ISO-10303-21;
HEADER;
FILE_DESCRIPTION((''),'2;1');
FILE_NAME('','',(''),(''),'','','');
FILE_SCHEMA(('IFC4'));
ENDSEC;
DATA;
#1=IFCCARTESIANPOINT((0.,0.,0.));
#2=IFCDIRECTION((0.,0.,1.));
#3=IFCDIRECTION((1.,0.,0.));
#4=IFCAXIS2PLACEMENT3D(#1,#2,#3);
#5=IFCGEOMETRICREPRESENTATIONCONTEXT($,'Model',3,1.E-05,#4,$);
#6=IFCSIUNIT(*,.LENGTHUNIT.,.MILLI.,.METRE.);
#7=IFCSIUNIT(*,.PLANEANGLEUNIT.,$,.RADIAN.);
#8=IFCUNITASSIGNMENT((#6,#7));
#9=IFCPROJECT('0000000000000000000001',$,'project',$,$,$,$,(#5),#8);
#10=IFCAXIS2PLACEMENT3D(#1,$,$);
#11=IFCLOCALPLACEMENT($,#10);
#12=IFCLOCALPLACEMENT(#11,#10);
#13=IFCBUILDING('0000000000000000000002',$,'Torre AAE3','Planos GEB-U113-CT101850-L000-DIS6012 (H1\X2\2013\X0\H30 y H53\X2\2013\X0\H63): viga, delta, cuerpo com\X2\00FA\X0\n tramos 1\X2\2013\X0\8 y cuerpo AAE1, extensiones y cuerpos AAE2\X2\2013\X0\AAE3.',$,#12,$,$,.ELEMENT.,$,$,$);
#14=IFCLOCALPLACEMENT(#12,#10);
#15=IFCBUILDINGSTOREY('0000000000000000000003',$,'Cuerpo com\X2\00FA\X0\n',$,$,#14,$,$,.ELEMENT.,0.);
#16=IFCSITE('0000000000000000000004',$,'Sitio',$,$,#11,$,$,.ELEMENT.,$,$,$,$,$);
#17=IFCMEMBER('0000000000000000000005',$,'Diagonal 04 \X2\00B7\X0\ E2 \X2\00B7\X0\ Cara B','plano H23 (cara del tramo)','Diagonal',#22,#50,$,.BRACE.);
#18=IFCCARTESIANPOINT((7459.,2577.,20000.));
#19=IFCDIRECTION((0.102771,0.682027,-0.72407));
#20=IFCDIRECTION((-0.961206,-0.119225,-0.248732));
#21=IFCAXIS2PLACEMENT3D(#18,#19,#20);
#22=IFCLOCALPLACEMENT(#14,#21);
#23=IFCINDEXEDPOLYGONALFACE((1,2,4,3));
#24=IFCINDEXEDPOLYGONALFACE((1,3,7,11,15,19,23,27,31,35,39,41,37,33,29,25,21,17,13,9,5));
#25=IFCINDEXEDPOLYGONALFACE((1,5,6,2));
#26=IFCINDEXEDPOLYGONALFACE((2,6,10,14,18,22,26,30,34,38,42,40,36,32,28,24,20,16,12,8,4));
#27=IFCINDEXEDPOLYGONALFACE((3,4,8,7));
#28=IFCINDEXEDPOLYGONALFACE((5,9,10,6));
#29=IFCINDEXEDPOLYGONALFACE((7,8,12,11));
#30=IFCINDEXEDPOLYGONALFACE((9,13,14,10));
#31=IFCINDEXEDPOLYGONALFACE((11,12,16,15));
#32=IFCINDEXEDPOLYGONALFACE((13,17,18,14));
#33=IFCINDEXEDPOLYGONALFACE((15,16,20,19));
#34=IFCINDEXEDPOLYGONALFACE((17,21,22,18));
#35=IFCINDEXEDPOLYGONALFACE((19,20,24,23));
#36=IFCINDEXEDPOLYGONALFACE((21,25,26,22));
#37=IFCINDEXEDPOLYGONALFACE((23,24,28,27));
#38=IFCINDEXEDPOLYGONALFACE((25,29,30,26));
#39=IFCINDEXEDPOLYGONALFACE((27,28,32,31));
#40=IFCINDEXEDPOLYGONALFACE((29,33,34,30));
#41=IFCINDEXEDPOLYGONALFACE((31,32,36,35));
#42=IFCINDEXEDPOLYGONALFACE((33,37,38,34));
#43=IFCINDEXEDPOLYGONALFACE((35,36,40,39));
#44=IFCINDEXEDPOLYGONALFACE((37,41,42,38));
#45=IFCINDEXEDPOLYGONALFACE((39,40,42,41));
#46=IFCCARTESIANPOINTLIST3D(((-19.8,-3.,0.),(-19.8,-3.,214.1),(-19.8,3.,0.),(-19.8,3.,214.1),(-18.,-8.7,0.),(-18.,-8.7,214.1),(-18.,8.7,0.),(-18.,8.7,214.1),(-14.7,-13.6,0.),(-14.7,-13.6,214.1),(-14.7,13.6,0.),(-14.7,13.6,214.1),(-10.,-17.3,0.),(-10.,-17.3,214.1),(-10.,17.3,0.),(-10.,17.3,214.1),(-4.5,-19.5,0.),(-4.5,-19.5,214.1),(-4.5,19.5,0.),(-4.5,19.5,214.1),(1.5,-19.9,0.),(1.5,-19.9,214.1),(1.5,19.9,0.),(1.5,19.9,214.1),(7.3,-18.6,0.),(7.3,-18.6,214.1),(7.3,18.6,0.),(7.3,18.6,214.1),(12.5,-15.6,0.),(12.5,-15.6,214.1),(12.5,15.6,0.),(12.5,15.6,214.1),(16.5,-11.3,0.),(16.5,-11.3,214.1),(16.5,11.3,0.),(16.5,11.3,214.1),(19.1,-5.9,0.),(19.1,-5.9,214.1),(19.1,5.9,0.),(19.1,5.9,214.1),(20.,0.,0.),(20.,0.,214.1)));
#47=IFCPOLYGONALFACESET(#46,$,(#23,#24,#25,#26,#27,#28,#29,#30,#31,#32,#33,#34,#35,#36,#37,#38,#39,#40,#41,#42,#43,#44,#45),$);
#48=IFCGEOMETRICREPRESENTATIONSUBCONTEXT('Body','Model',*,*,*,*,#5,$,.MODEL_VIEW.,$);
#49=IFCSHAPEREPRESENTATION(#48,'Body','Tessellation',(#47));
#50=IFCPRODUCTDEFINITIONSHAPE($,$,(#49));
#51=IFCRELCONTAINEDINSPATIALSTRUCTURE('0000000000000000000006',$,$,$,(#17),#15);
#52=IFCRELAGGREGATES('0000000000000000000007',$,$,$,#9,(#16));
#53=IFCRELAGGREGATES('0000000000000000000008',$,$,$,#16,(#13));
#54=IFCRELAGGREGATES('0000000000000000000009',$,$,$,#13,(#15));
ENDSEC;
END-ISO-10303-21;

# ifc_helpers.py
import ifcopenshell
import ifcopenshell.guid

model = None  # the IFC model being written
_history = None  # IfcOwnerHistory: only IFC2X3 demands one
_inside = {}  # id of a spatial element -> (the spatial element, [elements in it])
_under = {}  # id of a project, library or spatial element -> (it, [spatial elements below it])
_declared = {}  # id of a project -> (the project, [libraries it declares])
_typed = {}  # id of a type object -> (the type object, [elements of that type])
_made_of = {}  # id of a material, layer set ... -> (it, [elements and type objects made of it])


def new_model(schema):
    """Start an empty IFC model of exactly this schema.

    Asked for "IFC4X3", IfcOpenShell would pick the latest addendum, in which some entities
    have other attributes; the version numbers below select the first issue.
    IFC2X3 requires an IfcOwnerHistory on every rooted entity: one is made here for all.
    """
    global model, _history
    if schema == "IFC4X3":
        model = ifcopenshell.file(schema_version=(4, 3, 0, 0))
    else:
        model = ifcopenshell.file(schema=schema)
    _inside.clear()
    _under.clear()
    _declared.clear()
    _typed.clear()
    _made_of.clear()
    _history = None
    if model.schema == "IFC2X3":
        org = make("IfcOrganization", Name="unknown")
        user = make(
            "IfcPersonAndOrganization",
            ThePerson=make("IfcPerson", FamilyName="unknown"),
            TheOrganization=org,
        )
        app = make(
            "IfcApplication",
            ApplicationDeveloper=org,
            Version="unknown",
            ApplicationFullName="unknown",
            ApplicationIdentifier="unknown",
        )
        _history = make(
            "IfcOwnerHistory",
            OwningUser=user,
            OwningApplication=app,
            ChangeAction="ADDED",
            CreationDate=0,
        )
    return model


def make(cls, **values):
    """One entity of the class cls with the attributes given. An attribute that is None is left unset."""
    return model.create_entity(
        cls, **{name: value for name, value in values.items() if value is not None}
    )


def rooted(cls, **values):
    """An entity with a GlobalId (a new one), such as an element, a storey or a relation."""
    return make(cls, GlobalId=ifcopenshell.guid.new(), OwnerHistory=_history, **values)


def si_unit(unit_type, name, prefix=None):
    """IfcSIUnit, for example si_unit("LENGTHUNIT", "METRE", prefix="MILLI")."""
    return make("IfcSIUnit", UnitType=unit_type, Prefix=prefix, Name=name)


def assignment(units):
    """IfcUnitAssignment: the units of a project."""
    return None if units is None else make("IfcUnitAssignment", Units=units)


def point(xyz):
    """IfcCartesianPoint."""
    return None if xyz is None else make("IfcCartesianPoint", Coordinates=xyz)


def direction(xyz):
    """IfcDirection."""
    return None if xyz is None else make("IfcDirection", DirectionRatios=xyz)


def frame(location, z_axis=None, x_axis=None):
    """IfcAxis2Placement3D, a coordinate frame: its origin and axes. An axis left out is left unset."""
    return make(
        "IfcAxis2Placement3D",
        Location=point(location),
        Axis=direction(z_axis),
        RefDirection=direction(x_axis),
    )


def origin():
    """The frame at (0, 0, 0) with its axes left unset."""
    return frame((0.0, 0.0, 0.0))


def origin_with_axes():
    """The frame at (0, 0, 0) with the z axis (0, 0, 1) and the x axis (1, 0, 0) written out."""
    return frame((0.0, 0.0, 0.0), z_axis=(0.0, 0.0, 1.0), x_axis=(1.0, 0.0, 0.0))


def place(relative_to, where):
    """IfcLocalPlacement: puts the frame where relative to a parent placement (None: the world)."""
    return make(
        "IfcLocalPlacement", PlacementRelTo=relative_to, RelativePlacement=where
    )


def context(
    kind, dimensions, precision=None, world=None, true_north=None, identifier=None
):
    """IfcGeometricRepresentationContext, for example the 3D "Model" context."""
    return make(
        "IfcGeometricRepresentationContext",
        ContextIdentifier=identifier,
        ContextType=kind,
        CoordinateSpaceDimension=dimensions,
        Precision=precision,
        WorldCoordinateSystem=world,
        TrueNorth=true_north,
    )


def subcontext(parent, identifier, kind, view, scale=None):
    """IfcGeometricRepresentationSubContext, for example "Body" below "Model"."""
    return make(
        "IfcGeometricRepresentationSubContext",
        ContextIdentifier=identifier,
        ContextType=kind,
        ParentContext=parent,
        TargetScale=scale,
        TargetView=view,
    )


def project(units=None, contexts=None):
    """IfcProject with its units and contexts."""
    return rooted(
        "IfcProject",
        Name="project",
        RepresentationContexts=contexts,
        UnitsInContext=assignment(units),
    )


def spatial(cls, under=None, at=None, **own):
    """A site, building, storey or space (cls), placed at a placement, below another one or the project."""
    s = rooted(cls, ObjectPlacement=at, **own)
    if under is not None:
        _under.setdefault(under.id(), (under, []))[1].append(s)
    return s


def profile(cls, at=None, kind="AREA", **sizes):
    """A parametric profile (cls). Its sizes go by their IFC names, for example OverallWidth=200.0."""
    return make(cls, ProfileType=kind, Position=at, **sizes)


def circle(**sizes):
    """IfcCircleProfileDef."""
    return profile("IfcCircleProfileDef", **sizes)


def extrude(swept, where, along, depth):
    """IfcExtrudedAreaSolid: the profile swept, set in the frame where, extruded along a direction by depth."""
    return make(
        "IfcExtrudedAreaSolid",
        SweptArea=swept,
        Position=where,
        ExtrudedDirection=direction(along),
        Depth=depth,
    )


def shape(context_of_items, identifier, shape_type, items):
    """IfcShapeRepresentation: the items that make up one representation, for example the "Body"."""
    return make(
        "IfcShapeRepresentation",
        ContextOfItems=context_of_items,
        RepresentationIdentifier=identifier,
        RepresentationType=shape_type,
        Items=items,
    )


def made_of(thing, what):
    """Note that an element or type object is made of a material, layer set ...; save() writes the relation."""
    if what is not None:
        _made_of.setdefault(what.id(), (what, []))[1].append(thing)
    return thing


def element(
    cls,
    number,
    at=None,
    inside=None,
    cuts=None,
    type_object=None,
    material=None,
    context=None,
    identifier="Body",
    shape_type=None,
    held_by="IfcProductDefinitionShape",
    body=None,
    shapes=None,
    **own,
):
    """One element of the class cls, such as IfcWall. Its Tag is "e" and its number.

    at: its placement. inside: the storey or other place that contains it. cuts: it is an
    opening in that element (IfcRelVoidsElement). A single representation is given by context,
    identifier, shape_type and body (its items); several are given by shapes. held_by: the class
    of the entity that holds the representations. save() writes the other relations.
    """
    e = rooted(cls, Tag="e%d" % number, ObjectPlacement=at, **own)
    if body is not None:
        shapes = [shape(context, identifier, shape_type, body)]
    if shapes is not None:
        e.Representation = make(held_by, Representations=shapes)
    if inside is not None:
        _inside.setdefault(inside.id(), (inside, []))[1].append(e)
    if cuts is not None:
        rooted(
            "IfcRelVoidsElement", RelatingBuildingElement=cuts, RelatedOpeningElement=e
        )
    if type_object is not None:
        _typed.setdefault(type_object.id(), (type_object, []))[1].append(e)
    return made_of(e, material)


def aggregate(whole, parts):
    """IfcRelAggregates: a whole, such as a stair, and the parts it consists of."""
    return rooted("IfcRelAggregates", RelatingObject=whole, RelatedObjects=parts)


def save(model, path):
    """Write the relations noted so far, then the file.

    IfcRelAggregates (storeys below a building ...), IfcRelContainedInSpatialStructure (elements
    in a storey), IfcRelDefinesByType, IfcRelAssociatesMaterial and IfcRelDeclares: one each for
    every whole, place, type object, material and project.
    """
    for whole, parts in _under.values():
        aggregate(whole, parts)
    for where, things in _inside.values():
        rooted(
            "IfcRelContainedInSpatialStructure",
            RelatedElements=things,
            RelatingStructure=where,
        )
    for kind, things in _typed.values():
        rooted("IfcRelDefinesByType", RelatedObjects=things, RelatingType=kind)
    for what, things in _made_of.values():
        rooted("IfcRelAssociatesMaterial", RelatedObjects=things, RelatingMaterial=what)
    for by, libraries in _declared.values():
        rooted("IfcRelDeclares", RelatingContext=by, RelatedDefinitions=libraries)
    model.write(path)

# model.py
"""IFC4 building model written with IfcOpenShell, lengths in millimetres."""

from ifc_helpers import new_model, si_unit, frame, origin, origin_with_axes, place, context, subcontext, project, spatial, circle, extrude, element, save


model = new_model("IFC4")

# Units and contexts
model_context = context("Model", 3, precision=1e-05, world=origin_with_axes())
body_context = subcontext(model_context, "Body", "Model", "MODEL_VIEW")
ifc_project = project(units=[si_unit("LENGTHUNIT", "METRE", prefix="MILLI"), si_unit("PLANEANGLEUNIT", "RADIAN")], contexts=[model_context])

# Site, building, storey
site_placement = place(None, origin())
site = spatial("IfcSite", under=ifc_project, at=site_placement, Name="Sitio", CompositionType="ELEMENT")
building_placement = place(site_placement, origin())
building = spatial("IfcBuilding", under=site, at=building_placement, Name="Torre AAE3", Description="Planos GEB-U113-CT101850-L000-DIS6012 (H1–H30 y H53–H63): viga, delta, cuerpo común tramos 1–8 y cuerpo AAE1, extensiones y cuerpos AAE2–AAE3.", CompositionType="ELEMENT")
storey_placement = place(building_placement, origin())
storey = spatial("IfcBuildingStorey", under=building, at=storey_placement, Name="Cuerpo común", CompositionType="ELEMENT", Elevation=0.0)

# Member
member_1_placement = place(storey_placement, frame((7459.0, 2577.0, 20000.0), z_axis=(0.102771, 0.682027, -0.72407), x_axis=(-0.961206, -0.119225, -0.248732)))
element("IfcMember", 1, at=member_1_placement, inside=storey, Name="Diagonal 04 · E2 · Cara B", Description="plano H23 (cara del tramo)", ObjectType="Diagonal", PredefinedType="BRACE", context=body_context, shape_type="SweptSolid", body=[
    extrude(circle(Radius=20.0), None, (0.0, 0.0, 1.0), 214.1),
])

save(model, "model.ifc")
